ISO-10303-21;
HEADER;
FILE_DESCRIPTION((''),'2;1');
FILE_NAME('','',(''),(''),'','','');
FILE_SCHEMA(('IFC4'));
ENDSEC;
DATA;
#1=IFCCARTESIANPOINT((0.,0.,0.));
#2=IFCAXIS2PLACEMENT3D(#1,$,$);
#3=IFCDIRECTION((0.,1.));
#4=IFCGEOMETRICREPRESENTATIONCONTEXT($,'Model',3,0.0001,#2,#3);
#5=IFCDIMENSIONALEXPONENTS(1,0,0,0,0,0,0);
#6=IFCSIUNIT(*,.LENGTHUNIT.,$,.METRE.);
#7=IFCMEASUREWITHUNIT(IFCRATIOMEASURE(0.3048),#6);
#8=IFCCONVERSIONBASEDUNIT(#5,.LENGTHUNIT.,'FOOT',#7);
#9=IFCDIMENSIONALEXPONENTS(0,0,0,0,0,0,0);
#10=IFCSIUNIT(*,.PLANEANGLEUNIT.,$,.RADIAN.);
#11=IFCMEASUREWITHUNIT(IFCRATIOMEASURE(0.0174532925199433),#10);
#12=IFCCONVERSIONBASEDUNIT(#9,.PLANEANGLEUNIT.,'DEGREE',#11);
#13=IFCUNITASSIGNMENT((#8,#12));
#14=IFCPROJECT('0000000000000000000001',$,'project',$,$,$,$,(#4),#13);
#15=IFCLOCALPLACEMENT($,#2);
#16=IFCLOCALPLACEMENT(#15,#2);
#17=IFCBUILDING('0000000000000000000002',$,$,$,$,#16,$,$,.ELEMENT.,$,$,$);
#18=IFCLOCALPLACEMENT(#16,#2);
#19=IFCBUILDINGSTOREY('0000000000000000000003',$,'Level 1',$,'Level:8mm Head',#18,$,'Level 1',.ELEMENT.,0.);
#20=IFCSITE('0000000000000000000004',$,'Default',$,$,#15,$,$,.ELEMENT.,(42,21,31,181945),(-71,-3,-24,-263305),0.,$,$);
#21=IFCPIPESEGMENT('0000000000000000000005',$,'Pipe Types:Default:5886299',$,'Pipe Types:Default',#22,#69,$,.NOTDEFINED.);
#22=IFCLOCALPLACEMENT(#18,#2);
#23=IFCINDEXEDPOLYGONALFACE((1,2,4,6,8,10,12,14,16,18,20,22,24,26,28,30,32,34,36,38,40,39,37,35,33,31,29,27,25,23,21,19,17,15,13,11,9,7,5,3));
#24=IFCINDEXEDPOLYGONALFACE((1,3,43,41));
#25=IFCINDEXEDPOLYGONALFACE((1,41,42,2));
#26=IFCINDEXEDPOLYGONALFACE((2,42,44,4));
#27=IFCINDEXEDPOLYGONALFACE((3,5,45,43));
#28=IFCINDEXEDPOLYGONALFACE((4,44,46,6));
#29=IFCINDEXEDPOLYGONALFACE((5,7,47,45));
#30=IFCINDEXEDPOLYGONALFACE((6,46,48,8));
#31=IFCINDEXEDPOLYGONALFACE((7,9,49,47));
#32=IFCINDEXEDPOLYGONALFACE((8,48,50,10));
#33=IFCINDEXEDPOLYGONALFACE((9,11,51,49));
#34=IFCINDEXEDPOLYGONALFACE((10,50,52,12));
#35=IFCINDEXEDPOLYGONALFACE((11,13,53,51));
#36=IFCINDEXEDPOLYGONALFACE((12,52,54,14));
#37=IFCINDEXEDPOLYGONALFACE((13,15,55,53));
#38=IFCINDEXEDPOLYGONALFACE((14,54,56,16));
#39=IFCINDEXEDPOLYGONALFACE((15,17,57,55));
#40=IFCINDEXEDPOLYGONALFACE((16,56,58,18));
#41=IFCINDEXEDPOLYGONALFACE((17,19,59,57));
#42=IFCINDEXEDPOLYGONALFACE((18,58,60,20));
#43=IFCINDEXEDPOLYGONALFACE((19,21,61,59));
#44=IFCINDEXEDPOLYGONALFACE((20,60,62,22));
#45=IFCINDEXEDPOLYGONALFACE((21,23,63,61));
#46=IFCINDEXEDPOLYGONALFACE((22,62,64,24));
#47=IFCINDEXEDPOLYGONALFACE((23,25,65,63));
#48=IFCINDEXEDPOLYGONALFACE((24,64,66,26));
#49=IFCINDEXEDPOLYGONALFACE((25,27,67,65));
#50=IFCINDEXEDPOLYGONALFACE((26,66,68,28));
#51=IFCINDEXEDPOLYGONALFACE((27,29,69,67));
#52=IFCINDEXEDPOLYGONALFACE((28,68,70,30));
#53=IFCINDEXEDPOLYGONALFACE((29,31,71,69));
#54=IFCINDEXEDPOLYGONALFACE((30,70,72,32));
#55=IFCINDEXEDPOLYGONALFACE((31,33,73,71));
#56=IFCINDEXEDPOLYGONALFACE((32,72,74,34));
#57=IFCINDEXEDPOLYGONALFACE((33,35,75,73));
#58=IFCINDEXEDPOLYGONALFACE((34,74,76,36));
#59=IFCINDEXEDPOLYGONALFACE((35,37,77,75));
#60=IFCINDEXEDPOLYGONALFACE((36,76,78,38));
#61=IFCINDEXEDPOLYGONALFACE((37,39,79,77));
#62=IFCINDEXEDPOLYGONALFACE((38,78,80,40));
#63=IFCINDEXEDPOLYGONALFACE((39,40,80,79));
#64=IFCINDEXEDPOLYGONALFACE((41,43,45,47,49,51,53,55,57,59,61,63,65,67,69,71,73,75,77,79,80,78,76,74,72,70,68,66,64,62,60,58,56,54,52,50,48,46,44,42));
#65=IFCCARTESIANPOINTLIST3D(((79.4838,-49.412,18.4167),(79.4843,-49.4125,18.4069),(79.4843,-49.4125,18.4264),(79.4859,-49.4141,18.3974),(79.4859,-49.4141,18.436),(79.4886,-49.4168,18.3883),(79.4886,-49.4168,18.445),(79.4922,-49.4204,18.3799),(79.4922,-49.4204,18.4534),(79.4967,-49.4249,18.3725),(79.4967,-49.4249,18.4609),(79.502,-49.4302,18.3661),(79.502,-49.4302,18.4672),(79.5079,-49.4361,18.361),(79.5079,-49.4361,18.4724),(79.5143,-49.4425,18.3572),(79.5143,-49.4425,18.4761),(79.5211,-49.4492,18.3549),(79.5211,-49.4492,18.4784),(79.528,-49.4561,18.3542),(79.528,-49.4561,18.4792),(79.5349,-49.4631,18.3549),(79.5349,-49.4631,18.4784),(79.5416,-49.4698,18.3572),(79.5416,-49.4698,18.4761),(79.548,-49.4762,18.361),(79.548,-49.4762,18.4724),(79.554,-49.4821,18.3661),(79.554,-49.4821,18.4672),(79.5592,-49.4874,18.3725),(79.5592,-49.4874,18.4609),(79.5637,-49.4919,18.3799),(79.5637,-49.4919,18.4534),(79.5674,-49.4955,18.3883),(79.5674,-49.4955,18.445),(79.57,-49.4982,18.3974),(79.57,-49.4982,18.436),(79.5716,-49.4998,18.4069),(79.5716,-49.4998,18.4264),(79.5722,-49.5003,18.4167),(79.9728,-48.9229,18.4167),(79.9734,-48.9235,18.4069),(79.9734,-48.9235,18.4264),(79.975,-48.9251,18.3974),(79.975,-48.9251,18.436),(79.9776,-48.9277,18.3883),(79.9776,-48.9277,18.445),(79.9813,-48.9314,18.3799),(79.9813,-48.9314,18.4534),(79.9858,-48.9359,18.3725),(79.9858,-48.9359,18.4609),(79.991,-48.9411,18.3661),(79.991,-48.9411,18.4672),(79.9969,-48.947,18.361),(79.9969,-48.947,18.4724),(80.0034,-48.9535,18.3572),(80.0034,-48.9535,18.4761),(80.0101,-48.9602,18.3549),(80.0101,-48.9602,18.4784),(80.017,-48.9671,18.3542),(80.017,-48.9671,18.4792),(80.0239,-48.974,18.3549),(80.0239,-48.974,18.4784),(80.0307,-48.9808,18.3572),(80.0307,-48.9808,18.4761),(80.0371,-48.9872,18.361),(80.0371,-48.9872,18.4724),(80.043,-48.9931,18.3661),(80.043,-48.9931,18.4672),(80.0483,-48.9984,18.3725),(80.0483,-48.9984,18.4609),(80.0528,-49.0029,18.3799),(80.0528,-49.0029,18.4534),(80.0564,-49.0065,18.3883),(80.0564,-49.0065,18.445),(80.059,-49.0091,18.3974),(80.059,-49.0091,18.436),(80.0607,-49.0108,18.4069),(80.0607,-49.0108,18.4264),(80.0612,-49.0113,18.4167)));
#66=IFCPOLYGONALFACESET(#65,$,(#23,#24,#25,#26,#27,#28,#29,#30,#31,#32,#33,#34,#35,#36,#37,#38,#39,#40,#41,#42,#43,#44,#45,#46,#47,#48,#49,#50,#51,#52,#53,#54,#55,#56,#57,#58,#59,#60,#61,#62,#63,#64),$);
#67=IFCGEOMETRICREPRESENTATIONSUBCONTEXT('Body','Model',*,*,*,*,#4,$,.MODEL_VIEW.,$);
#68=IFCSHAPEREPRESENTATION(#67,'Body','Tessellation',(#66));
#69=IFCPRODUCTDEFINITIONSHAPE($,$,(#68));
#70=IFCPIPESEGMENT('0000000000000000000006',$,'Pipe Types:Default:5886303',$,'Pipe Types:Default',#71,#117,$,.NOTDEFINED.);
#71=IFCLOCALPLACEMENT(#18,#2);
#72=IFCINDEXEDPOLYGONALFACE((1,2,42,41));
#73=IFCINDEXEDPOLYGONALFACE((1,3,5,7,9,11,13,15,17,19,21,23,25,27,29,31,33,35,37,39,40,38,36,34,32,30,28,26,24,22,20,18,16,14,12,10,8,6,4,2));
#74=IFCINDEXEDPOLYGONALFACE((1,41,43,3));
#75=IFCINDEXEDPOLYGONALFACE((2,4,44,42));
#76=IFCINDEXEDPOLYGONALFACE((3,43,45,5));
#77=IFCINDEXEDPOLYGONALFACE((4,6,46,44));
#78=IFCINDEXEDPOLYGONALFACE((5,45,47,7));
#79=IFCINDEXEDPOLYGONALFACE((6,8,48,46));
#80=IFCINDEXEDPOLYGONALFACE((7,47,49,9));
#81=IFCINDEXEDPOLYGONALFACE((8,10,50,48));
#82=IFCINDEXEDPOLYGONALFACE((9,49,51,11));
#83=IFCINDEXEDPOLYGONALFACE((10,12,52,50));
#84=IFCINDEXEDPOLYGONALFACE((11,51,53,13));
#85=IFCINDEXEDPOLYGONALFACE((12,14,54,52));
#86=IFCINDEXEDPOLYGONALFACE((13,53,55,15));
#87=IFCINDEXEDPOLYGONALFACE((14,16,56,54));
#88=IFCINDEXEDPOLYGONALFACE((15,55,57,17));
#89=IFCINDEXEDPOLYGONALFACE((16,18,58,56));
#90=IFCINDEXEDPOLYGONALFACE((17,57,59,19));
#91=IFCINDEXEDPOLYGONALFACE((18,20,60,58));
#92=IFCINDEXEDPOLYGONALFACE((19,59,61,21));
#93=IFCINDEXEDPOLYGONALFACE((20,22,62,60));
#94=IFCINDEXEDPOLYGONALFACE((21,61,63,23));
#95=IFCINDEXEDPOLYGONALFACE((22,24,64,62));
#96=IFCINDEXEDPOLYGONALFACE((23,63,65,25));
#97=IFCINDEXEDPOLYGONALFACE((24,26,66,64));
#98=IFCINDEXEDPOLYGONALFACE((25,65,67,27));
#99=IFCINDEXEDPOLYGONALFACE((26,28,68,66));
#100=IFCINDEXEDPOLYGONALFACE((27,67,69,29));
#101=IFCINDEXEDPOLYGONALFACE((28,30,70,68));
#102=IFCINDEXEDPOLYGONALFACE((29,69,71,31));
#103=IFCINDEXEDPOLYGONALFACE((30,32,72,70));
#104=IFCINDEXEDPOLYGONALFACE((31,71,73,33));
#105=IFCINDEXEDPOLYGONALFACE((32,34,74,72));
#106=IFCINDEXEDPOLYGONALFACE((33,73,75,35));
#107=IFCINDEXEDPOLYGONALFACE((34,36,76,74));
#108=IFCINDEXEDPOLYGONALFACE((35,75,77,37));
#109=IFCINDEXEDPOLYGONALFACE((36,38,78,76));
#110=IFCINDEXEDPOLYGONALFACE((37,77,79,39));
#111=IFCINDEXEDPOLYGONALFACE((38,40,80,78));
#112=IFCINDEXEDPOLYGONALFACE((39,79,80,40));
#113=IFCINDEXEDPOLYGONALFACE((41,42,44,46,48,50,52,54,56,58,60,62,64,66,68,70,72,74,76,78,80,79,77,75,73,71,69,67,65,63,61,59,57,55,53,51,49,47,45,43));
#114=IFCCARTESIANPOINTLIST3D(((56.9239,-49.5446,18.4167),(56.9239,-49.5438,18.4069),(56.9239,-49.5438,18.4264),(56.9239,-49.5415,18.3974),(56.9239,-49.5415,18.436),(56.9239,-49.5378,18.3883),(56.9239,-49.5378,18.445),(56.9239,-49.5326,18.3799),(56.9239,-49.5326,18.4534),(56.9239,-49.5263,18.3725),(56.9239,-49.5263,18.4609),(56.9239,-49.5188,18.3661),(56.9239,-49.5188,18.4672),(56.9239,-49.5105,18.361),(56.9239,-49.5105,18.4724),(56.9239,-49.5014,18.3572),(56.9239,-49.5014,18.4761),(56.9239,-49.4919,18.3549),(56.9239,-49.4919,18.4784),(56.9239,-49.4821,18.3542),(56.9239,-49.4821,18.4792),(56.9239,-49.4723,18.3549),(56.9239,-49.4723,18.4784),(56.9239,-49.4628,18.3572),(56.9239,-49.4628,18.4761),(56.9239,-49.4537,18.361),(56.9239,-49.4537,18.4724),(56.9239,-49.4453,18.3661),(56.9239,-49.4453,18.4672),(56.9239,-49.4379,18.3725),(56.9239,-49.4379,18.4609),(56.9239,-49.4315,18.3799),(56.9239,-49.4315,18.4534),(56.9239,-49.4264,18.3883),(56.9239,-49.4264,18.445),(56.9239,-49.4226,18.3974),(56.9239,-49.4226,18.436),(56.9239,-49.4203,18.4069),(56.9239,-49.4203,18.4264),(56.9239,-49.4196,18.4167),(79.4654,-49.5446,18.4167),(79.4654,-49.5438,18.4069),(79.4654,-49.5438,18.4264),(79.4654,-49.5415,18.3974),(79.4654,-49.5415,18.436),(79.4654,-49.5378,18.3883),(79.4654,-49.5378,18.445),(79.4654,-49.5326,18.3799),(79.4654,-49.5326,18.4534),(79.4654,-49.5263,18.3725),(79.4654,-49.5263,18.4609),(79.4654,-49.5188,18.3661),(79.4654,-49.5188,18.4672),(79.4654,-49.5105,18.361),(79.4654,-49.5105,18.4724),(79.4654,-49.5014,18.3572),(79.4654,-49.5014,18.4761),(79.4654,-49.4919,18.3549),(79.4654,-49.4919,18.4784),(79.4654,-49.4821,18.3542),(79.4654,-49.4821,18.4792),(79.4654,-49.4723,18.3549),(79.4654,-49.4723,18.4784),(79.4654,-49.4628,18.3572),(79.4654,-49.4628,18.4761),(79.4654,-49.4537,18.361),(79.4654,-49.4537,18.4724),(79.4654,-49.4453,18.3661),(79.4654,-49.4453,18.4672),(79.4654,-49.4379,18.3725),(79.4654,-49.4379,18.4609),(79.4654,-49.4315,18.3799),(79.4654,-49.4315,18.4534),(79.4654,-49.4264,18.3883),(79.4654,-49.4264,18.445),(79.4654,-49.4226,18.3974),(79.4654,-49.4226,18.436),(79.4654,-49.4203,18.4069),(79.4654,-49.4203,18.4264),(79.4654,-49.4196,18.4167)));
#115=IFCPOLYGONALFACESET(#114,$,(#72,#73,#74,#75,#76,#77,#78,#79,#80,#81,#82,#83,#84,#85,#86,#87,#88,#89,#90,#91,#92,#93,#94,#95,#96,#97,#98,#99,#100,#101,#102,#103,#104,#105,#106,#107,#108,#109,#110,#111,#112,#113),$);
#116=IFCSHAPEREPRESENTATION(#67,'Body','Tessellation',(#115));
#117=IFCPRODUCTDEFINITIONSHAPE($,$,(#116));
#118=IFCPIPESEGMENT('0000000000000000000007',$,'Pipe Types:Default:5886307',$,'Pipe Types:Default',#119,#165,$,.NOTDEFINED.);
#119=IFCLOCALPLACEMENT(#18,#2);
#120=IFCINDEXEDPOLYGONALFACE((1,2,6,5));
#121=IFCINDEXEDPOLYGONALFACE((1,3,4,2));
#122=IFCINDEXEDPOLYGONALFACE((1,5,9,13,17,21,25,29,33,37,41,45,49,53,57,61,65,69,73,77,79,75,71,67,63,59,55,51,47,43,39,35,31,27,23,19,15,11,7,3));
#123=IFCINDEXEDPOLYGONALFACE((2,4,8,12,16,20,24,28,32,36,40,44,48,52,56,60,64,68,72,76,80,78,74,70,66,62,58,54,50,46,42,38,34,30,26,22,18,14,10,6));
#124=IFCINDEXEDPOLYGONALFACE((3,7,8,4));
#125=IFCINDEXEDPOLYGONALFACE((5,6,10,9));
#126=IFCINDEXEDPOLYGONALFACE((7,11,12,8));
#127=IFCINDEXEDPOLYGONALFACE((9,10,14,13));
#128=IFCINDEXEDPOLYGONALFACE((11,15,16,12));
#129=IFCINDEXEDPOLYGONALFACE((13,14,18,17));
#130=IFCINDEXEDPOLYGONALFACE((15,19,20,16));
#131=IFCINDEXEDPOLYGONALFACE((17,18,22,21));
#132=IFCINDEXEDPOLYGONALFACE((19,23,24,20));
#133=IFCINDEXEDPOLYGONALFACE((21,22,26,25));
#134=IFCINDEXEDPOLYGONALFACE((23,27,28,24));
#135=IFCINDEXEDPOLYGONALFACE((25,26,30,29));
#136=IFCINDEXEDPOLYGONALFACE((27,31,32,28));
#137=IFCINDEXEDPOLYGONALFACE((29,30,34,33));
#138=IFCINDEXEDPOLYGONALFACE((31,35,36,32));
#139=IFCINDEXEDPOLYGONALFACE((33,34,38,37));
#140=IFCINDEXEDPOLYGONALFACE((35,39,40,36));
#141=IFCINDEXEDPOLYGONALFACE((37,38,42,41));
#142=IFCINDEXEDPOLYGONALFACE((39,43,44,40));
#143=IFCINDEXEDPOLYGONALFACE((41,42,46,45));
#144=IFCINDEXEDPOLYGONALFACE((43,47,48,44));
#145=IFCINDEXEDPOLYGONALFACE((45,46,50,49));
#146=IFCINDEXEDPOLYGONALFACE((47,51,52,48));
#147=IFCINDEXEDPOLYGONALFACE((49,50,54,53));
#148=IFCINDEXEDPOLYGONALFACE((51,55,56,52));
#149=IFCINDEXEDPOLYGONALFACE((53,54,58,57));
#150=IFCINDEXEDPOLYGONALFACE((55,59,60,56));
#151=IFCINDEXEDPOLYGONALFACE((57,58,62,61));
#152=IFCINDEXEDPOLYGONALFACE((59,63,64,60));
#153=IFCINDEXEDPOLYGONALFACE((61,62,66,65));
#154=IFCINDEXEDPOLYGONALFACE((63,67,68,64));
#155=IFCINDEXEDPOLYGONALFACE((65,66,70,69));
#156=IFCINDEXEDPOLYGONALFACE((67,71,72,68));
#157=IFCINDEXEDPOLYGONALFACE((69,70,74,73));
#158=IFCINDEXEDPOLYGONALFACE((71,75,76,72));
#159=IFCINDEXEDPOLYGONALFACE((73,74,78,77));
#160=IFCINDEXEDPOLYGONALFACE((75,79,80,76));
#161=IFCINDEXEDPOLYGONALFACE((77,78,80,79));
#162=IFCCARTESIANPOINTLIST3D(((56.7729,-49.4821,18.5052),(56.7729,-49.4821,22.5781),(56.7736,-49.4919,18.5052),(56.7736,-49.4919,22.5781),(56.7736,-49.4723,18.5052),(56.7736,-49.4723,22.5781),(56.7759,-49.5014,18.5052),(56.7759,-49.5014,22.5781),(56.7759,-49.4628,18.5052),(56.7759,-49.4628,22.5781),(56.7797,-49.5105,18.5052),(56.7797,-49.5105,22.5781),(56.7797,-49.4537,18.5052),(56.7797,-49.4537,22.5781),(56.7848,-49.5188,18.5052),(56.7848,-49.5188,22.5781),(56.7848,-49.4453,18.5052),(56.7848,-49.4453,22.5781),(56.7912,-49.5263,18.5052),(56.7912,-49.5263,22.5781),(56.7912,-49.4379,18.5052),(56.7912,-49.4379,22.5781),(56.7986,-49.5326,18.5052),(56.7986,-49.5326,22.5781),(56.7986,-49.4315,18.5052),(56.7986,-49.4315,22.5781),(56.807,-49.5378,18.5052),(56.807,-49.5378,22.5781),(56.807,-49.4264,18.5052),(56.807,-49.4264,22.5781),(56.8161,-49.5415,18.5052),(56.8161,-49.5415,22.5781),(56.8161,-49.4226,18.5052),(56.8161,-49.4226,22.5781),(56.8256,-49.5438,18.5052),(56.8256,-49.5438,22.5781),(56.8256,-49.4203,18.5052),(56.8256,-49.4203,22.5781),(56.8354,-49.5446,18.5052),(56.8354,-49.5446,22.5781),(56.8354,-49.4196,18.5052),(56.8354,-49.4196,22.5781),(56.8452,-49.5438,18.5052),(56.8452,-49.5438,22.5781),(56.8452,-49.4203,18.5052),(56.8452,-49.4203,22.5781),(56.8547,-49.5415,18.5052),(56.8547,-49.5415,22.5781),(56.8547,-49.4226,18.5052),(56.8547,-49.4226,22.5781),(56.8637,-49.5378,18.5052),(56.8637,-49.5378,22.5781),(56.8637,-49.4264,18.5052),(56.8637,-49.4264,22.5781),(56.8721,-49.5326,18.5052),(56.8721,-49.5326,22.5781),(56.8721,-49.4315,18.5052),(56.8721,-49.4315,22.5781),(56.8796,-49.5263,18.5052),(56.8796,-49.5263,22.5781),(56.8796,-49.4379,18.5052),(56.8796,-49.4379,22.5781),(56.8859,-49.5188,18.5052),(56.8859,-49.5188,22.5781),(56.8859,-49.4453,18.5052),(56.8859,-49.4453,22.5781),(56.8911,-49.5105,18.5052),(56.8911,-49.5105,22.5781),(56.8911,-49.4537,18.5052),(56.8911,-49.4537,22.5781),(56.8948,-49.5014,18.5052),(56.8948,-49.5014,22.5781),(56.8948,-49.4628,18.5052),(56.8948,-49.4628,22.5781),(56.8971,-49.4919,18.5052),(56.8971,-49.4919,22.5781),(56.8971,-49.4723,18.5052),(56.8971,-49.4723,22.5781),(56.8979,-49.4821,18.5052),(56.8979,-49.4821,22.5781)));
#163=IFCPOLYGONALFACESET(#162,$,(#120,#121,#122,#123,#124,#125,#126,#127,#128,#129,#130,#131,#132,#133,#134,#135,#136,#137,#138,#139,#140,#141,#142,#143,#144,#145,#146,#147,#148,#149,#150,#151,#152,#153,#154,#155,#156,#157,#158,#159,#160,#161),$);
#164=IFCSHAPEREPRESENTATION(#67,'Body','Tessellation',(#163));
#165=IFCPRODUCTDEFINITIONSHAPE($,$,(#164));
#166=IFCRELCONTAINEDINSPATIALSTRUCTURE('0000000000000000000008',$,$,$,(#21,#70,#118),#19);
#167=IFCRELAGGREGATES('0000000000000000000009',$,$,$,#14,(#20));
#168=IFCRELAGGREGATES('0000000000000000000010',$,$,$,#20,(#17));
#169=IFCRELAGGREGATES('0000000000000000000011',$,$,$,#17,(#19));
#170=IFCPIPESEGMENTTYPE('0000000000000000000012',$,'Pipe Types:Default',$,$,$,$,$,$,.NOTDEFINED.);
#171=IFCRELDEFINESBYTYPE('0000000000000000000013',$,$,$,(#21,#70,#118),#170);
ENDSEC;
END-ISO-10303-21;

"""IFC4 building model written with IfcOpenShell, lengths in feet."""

from ifc_helpers import new_model, entity, si_unit, converted_unit, direction, frame, origin, place, context, subcontext, project, spatial, indexed_curve, outline, extrude, type_object, element, save


model = new_model("IFC4")

# Units and contexts
model_context = context("Model", 3, precision=0.0001, world=origin(), true_north=direction((0.0, 1.0)))
body_context = subcontext(model_context, "Body", "Model", "MODEL_VIEW")
ifc_project = project(units=[converted_unit("LENGTHUNIT", "FOOT", entity("IfcRatioMeasure", 0.3048), si_unit("LENGTHUNIT", "METRE"), dimensions=[1, 0, 0, 0, 0, 0, 0]), converted_unit("PLANEANGLEUNIT", "DEGREE", entity("IfcRatioMeasure", 0.0174532925199433), si_unit("PLANEANGLEUNIT", "RADIAN"), dimensions=[0, 0, 0, 0, 0, 0, 0])], contexts=[model_context])

# Site, building, storey
site_placement = place(None, origin())
site = spatial("IfcSite", under=ifc_project, at=site_placement, Name="Default", CompositionType="ELEMENT", RefLatitude=(42, 21, 31, 181945), RefLongitude=(-71, -3, -24, -263305), RefElevation=0.0)
building_placement = place(site_placement, origin())
building = spatial("IfcBuilding", under=site, at=building_placement, CompositionType="ELEMENT")
storey_placement = place(building_placement, origin())
storey = spatial("IfcBuildingStorey", under=building, at=storey_placement, Name="Level 1", ObjectType="Level:8mm Head", LongName="Level 1", CompositionType="ELEMENT", Elevation=0.0)

# Pipe segments
pipe_segment_type = type_object("IfcPipeSegmentType", Name="Pipe Types:Default", PredefinedType="NOTDEFINED")
pipe_segment_1_placement = place(storey_placement, origin())
element("IfcPipeSegment", 1, at=pipe_segment_1_placement, inside=storey, type_object=pipe_segment_type, Name="Pipe Types:Default:5886299", ObjectType="Pipe Types:Default", PredefinedType="NOTDEFINED", context=body_context, shape_type="SweptSolid", body=[
    extrude(outline(indexed_curve([(0.0625, 0.0), (0.0617, 0.0098), (0.0594, 0.0193), (0.0557, 0.0284), (0.0506, 0.0367), (0.0442, 0.0442), (0.0367, 0.0506), (0.0284, 0.0557), (0.0193, 0.0594), (0.0098, 0.0617), (0.0, 0.0625), (-0.0098, 0.0617), (-0.0193, 0.0594), (-0.0284, 0.0557), (-0.0367, 0.0506), (-0.0442, 0.0442), (-0.0506, 0.0367), (-0.0557, 0.0284), (-0.0594, 0.0193), (-0.0617, 0.0098), (-0.0625, 0.0), (-0.0617, -0.0098), (-0.0594, -0.0193), (-0.0557, -0.0284), (-0.0506, -0.0367), (-0.0442, -0.0442), (-0.0367, -0.0506), (-0.0284, -0.0557), (-0.0193, -0.0594), (-0.0098, -0.0617), (0.0, -0.0625), (0.0098, -0.0617), (0.0193, -0.0594), (0.0284, -0.0557), (0.0367, -0.0506), (0.0442, -0.0442), (0.0506, -0.0367), (0.0557, -0.0284), (0.0594, -0.0193), (0.0617, -0.0098), (0.0625, 0.0)], self_intersect=False)), frame((79.528, -49.4561, 18.4167), z_axis=(0.707107, 0.707107, 0.0), x_axis=(-0.707107, 0.707107, 0.0)), (0.0, 0.0, 1.0), 0.6916),
])
pipe_segment_2_placement = place(storey_placement, origin())
element("IfcPipeSegment", 2, at=pipe_segment_2_placement, inside=storey, type_object=pipe_segment_type, Name="Pipe Types:Default:5886303", ObjectType="Pipe Types:Default", PredefinedType="NOTDEFINED", context=body_context, shape_type="SweptSolid", body=[
    extrude(outline(indexed_curve([(0.0625, 0.0), (0.0617, 0.0098), (0.0594, 0.0193), (0.0557, 0.0284), (0.0506, 0.0367), (0.0442, 0.0442), (0.0367, 0.0506), (0.0284, 0.0557), (0.0193, 0.0594), (0.0098, 0.0617), (0.0, 0.0625), (-0.0098, 0.0617), (-0.0193, 0.0594), (-0.0284, 0.0557), (-0.0367, 0.0506), (-0.0442, 0.0442), (-0.0506, 0.0367), (-0.0557, 0.0284), (-0.0594, 0.0193), (-0.0617, 0.0098), (-0.0625, 0.0), (-0.0617, -0.0098), (-0.0594, -0.0193), (-0.0557, -0.0284), (-0.0506, -0.0367), (-0.0442, -0.0442), (-0.0367, -0.0506), (-0.0284, -0.0557), (-0.0193, -0.0594), (-0.0098, -0.0617), (0.0, -0.0625), (0.0098, -0.0617), (0.0193, -0.0594), (0.0284, -0.0557), (0.0367, -0.0506), (0.0442, -0.0442), (0.0506, -0.0367), (0.0557, -0.0284), (0.0594, -0.0193), (0.0617, -0.0098), (0.0625, 0.0)], self_intersect=False)), frame((56.9239, -49.4821, 18.4167), z_axis=(1.0, 0.0, 0.0), x_axis=(0.0, 1.0, 0.0)), (0.0, 0.0, 1.0), 22.5414),
])
pipe_segment_3_placement = place(storey_placement, origin())
element("IfcPipeSegment", 3, at=pipe_segment_3_placement, inside=storey, type_object=pipe_segment_type, Name="Pipe Types:Default:5886307", ObjectType="Pipe Types:Default", PredefinedType="NOTDEFINED", context=body_context, shape_type="SweptSolid", body=[
    extrude(outline(indexed_curve([(0.0625, 0.0), (0.0617, 0.0098), (0.0594, 0.0193), (0.0557, 0.0284), (0.0506, 0.0367), (0.0442, 0.0442), (0.0367, 0.0506), (0.0284, 0.0557), (0.0193, 0.0594), (0.0098, 0.0617), (0.0, 0.0625), (-0.0098, 0.0617), (-0.0193, 0.0594), (-0.0284, 0.0557), (-0.0367, 0.0506), (-0.0442, 0.0442), (-0.0506, 0.0367), (-0.0557, 0.0284), (-0.0594, 0.0193), (-0.0617, 0.0098), (-0.0625, 0.0), (-0.0617, -0.0098), (-0.0594, -0.0193), (-0.0557, -0.0284), (-0.0506, -0.0367), (-0.0442, -0.0442), (-0.0367, -0.0506), (-0.0284, -0.0557), (-0.0193, -0.0594), (-0.0098, -0.0617), (0.0, -0.0625), (0.0098, -0.0617), (0.0193, -0.0594), (0.0284, -0.0557), (0.0367, -0.0506), (0.0442, -0.0442), (0.0506, -0.0367), (0.0557, -0.0284), (0.0594, -0.0193), (0.0617, -0.0098), (0.0625, 0.0)], self_intersect=False)), frame((56.8354, -49.4821, 18.5052), z_axis=(0.0, 0.0, 1.0), x_axis=(-1.0, 0.0, 0.0)), (0.0, 0.0, 1.0), 4.0729),
])

save(model, "model.ifc")
